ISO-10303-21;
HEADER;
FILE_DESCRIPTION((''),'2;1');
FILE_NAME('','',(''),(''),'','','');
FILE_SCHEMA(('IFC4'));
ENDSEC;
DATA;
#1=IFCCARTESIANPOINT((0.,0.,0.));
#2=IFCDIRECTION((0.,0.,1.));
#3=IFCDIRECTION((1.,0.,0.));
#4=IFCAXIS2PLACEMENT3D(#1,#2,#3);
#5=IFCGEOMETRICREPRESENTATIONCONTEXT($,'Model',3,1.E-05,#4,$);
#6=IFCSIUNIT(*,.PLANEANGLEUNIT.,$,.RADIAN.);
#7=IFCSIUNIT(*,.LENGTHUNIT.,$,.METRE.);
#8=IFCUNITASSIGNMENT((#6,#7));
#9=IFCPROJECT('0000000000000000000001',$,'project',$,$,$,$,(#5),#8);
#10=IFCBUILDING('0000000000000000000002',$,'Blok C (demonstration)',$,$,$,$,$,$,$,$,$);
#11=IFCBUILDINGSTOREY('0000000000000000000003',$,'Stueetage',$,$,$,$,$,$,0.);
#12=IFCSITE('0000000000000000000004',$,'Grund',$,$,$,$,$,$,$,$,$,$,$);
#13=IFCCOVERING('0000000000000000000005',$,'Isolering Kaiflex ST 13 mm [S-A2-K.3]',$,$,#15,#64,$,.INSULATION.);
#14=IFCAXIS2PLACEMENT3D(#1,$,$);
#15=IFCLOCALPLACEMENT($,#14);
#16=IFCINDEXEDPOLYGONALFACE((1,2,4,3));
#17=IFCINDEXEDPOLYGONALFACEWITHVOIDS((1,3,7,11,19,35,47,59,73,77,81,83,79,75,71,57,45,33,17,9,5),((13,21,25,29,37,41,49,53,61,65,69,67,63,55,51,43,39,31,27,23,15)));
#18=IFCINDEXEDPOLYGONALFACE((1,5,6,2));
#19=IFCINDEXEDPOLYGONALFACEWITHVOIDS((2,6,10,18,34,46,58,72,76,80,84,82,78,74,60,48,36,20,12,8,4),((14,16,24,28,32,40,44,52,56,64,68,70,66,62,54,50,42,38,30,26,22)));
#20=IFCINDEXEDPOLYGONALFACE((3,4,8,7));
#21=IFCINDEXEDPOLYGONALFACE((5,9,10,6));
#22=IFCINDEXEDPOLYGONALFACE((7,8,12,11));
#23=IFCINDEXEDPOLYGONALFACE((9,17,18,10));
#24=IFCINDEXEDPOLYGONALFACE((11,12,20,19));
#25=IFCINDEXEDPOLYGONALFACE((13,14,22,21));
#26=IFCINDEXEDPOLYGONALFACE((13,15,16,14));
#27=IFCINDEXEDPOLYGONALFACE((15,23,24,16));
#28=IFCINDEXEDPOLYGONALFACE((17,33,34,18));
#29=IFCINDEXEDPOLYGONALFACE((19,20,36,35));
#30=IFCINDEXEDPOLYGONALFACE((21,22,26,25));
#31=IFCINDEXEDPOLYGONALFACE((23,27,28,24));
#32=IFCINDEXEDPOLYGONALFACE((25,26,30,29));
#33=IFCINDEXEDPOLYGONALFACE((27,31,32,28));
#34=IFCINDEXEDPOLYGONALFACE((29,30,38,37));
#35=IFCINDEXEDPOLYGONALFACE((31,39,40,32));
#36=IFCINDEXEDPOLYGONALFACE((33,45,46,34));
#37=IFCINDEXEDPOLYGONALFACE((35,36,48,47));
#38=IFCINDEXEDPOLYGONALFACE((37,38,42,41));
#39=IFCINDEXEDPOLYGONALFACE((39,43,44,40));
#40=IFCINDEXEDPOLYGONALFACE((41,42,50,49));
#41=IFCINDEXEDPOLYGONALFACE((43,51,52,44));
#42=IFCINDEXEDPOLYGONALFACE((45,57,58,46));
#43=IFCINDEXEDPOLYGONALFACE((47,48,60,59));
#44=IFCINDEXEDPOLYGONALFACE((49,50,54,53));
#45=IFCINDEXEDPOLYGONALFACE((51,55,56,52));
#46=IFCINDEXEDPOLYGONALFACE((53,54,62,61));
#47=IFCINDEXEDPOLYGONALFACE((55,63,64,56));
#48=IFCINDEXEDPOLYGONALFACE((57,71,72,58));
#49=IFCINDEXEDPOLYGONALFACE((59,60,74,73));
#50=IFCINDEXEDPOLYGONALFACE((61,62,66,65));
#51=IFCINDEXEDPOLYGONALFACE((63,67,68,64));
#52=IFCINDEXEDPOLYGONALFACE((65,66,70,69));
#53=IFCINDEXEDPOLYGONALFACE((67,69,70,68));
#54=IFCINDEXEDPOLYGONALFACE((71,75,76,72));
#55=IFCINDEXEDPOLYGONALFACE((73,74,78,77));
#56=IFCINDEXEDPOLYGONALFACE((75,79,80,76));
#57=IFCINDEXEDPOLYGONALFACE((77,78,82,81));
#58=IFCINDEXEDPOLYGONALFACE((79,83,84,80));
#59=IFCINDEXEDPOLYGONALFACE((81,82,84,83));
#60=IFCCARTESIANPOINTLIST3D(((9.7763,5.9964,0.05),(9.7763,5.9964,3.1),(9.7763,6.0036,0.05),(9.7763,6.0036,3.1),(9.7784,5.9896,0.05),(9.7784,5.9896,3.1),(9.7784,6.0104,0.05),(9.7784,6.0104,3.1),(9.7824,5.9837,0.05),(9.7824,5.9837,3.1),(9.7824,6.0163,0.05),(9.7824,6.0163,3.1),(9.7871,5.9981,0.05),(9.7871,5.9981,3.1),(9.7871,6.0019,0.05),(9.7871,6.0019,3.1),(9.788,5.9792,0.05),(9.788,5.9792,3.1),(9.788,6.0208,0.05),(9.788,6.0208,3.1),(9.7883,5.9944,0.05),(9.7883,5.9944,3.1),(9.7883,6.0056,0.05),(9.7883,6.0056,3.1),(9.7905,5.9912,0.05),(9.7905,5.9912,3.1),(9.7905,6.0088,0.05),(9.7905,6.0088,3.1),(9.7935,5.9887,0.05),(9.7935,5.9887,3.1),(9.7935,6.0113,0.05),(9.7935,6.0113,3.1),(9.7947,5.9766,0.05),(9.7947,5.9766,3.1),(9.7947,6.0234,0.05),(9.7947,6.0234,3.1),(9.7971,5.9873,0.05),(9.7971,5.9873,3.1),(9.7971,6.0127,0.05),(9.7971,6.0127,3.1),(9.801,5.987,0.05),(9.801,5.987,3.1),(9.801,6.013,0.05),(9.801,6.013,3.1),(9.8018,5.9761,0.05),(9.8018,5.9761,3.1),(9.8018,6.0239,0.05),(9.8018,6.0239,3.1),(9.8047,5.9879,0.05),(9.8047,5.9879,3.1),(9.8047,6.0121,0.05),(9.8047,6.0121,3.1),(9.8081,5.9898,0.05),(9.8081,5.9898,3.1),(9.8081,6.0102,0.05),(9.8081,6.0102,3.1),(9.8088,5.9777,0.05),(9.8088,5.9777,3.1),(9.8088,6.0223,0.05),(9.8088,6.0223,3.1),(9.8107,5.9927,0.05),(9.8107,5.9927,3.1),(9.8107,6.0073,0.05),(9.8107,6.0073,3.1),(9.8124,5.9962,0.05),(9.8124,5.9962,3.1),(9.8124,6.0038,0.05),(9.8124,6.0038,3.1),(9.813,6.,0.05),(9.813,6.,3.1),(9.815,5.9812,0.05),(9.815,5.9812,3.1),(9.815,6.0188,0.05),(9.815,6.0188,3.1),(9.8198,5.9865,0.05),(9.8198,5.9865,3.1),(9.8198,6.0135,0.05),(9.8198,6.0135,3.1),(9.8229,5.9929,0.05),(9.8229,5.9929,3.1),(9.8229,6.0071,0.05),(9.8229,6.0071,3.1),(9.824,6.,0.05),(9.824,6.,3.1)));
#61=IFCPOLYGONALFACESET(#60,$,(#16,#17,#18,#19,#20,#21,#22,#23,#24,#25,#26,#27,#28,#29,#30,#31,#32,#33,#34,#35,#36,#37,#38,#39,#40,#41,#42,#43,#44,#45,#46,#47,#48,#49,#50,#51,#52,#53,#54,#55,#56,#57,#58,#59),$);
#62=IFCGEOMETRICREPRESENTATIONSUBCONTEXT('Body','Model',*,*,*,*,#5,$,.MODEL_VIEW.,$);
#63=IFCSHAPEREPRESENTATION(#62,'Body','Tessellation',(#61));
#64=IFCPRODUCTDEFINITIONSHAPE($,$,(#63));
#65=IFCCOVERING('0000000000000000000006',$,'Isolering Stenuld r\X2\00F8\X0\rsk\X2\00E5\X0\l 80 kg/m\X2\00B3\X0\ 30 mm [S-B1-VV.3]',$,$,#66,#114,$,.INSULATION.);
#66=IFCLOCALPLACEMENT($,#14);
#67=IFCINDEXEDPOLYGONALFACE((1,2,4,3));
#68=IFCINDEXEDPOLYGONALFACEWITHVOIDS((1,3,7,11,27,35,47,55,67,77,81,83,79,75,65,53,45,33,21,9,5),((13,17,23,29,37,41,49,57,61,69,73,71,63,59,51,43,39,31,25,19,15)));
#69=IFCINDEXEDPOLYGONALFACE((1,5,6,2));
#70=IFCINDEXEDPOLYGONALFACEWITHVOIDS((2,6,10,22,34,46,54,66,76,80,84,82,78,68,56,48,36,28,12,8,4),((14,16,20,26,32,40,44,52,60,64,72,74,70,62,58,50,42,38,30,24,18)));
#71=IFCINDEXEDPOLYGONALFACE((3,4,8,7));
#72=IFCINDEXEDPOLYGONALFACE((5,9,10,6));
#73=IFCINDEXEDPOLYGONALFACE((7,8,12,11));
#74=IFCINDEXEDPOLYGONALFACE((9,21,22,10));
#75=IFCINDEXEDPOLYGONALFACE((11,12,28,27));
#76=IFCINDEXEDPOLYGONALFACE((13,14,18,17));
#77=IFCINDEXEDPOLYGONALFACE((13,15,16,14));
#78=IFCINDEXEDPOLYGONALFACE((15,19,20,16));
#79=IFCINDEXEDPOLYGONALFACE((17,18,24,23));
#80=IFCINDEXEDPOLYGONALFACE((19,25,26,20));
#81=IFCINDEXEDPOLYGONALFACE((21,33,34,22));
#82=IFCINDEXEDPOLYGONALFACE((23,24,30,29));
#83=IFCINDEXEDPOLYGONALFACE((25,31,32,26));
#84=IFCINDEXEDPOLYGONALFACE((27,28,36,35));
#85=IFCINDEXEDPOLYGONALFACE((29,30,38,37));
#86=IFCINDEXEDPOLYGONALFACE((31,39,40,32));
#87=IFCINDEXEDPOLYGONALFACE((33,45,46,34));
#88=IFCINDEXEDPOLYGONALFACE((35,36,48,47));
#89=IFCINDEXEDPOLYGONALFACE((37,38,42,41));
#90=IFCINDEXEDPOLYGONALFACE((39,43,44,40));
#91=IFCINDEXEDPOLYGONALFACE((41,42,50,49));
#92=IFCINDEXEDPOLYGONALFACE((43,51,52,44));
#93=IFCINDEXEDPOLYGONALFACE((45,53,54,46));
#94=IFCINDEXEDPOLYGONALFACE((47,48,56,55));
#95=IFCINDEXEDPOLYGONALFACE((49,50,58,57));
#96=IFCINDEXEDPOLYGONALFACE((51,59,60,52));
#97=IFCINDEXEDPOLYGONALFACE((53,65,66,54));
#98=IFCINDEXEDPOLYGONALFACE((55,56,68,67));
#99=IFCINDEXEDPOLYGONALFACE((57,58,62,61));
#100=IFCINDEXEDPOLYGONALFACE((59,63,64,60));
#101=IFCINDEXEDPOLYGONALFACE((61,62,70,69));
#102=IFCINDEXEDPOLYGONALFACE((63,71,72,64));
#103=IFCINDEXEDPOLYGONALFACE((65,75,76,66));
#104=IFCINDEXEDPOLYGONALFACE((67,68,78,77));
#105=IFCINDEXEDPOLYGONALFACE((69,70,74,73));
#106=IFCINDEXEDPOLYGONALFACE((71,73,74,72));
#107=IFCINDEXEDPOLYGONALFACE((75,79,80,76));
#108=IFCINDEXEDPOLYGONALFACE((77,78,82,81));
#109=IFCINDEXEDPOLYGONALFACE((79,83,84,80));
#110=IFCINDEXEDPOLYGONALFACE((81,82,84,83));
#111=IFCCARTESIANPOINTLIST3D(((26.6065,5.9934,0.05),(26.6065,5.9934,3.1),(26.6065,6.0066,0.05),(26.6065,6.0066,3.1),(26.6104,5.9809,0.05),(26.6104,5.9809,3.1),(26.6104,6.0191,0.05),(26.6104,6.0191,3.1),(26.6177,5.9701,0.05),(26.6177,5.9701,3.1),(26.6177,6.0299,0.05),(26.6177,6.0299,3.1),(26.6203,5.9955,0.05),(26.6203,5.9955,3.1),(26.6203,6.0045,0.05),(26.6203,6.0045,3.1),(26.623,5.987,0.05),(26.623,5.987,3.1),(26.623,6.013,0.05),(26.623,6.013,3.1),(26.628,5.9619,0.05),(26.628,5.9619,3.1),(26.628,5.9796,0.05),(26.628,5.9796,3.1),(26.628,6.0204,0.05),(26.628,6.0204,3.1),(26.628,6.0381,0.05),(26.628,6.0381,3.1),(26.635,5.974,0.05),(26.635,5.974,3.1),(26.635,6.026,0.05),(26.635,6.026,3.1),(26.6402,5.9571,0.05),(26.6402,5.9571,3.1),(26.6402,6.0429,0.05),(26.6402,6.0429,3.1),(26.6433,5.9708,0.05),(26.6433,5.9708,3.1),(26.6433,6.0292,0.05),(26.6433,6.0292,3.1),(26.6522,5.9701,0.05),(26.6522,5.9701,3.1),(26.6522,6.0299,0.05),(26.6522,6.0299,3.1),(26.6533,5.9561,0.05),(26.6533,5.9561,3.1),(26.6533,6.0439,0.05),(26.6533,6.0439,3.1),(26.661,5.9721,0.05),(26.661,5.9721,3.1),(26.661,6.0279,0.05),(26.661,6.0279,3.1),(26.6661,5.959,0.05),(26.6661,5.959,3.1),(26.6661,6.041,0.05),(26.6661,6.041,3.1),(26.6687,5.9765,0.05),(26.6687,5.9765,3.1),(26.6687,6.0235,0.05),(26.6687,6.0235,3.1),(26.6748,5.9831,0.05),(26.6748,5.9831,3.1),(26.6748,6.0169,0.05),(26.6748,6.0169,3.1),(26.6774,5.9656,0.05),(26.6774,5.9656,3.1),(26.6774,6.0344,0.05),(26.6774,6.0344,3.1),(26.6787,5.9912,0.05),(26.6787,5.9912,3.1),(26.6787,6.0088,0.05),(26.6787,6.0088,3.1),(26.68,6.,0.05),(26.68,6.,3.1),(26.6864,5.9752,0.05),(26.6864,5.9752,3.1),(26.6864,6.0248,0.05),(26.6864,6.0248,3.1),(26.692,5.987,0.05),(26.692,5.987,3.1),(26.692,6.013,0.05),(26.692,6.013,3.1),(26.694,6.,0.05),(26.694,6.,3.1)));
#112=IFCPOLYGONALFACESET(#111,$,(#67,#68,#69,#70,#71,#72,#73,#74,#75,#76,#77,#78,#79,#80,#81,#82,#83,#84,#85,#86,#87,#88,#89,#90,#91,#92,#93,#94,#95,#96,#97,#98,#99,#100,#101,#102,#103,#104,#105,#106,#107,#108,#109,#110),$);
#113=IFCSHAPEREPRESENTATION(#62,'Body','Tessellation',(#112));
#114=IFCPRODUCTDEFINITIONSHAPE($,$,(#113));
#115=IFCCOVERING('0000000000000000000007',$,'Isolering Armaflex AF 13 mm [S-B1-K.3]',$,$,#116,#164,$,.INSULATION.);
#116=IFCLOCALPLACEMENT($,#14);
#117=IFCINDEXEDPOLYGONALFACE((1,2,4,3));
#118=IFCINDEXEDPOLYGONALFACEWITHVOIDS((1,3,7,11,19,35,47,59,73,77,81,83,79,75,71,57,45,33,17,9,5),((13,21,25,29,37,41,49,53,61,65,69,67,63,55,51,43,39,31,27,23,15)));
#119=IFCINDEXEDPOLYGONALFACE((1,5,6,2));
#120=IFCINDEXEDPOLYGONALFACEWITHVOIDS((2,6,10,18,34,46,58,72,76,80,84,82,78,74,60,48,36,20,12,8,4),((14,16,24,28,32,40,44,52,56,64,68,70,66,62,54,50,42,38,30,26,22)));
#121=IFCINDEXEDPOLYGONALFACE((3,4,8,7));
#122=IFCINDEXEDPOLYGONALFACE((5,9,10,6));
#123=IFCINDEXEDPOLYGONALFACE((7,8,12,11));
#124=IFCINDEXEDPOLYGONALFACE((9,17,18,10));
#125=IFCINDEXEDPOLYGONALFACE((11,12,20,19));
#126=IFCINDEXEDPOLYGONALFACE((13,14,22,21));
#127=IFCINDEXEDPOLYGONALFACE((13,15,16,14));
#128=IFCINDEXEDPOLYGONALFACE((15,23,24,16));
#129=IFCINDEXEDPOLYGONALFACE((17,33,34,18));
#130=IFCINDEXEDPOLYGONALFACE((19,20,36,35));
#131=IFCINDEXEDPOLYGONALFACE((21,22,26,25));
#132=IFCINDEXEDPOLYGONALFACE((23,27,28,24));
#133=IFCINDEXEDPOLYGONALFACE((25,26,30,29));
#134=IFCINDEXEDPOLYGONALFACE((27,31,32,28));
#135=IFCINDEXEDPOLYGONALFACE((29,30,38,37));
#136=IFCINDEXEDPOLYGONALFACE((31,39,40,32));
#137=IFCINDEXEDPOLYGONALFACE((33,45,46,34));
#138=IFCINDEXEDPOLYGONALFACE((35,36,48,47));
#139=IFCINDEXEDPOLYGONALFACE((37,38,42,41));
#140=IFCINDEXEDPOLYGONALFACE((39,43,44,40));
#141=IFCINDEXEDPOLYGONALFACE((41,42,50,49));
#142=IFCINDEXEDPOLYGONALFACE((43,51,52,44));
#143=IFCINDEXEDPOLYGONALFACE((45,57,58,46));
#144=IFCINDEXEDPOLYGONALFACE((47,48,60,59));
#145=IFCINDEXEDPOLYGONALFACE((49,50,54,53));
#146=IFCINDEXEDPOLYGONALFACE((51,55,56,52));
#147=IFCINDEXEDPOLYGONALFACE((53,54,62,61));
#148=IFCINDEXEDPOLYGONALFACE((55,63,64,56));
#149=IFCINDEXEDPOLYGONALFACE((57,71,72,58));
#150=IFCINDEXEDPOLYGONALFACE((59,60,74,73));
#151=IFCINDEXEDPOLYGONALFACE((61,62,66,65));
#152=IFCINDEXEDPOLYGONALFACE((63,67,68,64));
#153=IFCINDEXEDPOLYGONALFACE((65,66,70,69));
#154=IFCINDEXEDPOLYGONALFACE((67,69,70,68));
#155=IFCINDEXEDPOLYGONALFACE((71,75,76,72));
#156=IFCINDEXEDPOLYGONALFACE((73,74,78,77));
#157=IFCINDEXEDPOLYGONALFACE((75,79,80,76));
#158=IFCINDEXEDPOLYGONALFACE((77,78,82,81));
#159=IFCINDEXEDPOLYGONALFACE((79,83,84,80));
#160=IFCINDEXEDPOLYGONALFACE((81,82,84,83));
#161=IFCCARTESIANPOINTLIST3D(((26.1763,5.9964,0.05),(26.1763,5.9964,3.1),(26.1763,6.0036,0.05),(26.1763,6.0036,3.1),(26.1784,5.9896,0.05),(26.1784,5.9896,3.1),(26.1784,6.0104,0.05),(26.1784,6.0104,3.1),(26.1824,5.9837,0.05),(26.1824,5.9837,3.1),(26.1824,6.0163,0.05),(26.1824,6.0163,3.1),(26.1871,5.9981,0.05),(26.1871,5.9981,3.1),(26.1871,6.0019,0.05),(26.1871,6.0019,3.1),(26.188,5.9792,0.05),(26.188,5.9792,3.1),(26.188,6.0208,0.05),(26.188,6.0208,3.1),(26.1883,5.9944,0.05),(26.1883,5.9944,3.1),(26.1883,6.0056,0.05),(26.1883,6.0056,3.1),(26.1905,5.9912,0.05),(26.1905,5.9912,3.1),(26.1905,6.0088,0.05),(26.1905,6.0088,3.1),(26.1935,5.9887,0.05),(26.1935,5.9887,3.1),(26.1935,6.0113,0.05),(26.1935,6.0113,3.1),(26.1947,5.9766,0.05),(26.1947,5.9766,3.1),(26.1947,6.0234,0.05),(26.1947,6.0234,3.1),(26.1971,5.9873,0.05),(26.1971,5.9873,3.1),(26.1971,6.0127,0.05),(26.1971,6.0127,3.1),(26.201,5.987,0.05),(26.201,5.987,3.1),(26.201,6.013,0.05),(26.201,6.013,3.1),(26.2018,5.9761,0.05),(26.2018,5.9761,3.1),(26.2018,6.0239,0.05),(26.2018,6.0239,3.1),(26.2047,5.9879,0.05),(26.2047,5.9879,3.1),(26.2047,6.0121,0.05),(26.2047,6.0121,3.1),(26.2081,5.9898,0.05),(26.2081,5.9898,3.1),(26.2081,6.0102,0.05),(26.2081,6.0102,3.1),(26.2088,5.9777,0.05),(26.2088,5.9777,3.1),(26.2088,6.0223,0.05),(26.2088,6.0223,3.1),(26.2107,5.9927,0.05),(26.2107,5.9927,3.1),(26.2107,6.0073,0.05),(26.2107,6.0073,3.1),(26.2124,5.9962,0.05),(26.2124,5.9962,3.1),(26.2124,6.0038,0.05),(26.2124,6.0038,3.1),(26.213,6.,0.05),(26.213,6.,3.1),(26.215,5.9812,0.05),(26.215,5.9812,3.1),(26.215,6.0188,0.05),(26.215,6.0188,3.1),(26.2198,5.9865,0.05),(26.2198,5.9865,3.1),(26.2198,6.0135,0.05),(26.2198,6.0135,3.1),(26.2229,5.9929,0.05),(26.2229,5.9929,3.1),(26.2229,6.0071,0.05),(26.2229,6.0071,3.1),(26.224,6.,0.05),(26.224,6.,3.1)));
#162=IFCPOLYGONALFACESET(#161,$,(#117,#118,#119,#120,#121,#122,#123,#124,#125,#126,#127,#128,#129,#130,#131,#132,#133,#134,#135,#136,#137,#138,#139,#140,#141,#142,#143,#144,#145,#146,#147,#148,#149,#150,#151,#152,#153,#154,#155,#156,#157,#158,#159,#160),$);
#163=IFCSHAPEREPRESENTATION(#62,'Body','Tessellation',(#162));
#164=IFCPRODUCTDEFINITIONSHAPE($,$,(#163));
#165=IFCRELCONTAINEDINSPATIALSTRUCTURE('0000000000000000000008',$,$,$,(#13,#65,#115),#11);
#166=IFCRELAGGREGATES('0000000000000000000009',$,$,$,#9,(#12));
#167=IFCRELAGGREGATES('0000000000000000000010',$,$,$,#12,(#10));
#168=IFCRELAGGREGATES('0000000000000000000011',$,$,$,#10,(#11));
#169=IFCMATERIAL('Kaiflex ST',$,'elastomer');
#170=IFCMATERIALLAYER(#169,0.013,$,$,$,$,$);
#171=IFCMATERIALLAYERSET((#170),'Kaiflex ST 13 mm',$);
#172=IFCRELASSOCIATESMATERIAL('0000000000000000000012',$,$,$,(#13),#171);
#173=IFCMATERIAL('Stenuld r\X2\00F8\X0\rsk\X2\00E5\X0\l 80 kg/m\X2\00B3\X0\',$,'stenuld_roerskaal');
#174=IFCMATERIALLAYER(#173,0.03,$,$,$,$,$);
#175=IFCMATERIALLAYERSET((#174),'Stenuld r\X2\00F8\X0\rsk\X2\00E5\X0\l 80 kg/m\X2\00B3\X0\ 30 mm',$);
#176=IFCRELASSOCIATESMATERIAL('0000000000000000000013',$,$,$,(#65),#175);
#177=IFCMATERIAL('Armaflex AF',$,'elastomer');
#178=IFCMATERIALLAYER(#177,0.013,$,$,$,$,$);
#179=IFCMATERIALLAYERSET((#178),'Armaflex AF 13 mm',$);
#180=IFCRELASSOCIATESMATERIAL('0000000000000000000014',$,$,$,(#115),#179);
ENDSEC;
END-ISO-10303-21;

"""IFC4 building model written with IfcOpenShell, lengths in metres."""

from ifc_helpers import new_model, si_unit, frame, origin_with_axes, place, context, subcontext, project, spatial, hollow_circle, extrude, material, layer, layer_set, element, save


model = new_model("IFC4")

# Units and contexts
model_context = context("Model", 3, precision=1e-05, world=origin_with_axes())
body_context = subcontext(model_context, "Body", "Model", "MODEL_VIEW")
ifc_project = project(units=[si_unit("PLANEANGLEUNIT", "RADIAN"), si_unit("LENGTHUNIT", "METRE")], contexts=[model_context])

# Site, building, storey
site = spatial("IfcSite", under=ifc_project, Name="Grund")
building = spatial("IfcBuilding", under=site, Name="Blok C (demonstration)")
storey = spatial("IfcBuildingStorey", under=building, Name="Stueetage", Elevation=0.0)

# Coverings
ifc_material_1 = material(Name="Stenuld rørskål 80 kg/m³", Category="stenuld_roerskaal")
ifc_material_2 = material(Name="Kaiflex ST", Category="elastomer")
ifc_layer_1 = layer(ifc_material_2, 0.013)
ifc_layer_set_1 = layer_set([ifc_layer_1], Name="Kaiflex ST 13 mm")
covering_1_placement = place(None, origin_with_axes())
element("IfcCovering", 1, at=covering_1_placement, inside=storey, material=ifc_layer_set_1, Name="Isolering Kaiflex ST 13 mm [S-A2-K.3]", PredefinedType="INSULATION", context=body_context, shape_type="SweptSolid", body=[
    extrude(hollow_circle(Radius=0.024, WallThickness=0.011), frame((9.8, 6.0, 0.05), z_axis=(0.0, 0.0, 1.0), x_axis=(1.0, 0.0, 0.0)), (0.0, 0.0, 1.0), 3.05),
])
ifc_layer_2 = layer(ifc_material_1, 0.03)
ifc_layer_set_2 = layer_set([ifc_layer_2], Name="Stenuld rørskål 80 kg/m³ 30 mm")
covering_2_placement = place(None, origin_with_axes())
element("IfcCovering", 2, at=covering_2_placement, inside=storey, material=ifc_layer_set_2, Name="Isolering Stenuld rørskål 80 kg/m³ 30 mm [S-B1-VV.3]", PredefinedType="INSULATION", context=body_context, shape_type="SweptSolid", body=[
    extrude(hollow_circle(Radius=0.044, WallThickness=0.014), frame((26.65, 6.0, 0.05), z_axis=(0.0, 0.0, 1.0), x_axis=(1.0, 0.0, 0.0)), (0.0, 0.0, 1.0), 3.05),
])
ifc_material_3 = material(Name="Armaflex AF", Category="elastomer")
ifc_layer_3 = layer(ifc_material_3, 0.013)
ifc_layer_set_3 = layer_set([ifc_layer_3], Name="Armaflex AF 13 mm")
covering_3_placement = place(None, origin_with_axes())
element("IfcCovering", 3, at=covering_3_placement, inside=storey, material=ifc_layer_set_3, Name="Isolering Armaflex AF 13 mm [S-B1-K.3]", PredefinedType="INSULATION", context=body_context, shape_type="SweptSolid", body=[
    extrude(hollow_circle(Radius=0.024, WallThickness=0.011), frame((26.2, 6.0, 0.05), z_axis=(0.0, 0.0, 1.0), x_axis=(1.0, 0.0, 0.0)), (0.0, 0.0, 1.0), 3.05),
])

save(model, "model.ifc")
